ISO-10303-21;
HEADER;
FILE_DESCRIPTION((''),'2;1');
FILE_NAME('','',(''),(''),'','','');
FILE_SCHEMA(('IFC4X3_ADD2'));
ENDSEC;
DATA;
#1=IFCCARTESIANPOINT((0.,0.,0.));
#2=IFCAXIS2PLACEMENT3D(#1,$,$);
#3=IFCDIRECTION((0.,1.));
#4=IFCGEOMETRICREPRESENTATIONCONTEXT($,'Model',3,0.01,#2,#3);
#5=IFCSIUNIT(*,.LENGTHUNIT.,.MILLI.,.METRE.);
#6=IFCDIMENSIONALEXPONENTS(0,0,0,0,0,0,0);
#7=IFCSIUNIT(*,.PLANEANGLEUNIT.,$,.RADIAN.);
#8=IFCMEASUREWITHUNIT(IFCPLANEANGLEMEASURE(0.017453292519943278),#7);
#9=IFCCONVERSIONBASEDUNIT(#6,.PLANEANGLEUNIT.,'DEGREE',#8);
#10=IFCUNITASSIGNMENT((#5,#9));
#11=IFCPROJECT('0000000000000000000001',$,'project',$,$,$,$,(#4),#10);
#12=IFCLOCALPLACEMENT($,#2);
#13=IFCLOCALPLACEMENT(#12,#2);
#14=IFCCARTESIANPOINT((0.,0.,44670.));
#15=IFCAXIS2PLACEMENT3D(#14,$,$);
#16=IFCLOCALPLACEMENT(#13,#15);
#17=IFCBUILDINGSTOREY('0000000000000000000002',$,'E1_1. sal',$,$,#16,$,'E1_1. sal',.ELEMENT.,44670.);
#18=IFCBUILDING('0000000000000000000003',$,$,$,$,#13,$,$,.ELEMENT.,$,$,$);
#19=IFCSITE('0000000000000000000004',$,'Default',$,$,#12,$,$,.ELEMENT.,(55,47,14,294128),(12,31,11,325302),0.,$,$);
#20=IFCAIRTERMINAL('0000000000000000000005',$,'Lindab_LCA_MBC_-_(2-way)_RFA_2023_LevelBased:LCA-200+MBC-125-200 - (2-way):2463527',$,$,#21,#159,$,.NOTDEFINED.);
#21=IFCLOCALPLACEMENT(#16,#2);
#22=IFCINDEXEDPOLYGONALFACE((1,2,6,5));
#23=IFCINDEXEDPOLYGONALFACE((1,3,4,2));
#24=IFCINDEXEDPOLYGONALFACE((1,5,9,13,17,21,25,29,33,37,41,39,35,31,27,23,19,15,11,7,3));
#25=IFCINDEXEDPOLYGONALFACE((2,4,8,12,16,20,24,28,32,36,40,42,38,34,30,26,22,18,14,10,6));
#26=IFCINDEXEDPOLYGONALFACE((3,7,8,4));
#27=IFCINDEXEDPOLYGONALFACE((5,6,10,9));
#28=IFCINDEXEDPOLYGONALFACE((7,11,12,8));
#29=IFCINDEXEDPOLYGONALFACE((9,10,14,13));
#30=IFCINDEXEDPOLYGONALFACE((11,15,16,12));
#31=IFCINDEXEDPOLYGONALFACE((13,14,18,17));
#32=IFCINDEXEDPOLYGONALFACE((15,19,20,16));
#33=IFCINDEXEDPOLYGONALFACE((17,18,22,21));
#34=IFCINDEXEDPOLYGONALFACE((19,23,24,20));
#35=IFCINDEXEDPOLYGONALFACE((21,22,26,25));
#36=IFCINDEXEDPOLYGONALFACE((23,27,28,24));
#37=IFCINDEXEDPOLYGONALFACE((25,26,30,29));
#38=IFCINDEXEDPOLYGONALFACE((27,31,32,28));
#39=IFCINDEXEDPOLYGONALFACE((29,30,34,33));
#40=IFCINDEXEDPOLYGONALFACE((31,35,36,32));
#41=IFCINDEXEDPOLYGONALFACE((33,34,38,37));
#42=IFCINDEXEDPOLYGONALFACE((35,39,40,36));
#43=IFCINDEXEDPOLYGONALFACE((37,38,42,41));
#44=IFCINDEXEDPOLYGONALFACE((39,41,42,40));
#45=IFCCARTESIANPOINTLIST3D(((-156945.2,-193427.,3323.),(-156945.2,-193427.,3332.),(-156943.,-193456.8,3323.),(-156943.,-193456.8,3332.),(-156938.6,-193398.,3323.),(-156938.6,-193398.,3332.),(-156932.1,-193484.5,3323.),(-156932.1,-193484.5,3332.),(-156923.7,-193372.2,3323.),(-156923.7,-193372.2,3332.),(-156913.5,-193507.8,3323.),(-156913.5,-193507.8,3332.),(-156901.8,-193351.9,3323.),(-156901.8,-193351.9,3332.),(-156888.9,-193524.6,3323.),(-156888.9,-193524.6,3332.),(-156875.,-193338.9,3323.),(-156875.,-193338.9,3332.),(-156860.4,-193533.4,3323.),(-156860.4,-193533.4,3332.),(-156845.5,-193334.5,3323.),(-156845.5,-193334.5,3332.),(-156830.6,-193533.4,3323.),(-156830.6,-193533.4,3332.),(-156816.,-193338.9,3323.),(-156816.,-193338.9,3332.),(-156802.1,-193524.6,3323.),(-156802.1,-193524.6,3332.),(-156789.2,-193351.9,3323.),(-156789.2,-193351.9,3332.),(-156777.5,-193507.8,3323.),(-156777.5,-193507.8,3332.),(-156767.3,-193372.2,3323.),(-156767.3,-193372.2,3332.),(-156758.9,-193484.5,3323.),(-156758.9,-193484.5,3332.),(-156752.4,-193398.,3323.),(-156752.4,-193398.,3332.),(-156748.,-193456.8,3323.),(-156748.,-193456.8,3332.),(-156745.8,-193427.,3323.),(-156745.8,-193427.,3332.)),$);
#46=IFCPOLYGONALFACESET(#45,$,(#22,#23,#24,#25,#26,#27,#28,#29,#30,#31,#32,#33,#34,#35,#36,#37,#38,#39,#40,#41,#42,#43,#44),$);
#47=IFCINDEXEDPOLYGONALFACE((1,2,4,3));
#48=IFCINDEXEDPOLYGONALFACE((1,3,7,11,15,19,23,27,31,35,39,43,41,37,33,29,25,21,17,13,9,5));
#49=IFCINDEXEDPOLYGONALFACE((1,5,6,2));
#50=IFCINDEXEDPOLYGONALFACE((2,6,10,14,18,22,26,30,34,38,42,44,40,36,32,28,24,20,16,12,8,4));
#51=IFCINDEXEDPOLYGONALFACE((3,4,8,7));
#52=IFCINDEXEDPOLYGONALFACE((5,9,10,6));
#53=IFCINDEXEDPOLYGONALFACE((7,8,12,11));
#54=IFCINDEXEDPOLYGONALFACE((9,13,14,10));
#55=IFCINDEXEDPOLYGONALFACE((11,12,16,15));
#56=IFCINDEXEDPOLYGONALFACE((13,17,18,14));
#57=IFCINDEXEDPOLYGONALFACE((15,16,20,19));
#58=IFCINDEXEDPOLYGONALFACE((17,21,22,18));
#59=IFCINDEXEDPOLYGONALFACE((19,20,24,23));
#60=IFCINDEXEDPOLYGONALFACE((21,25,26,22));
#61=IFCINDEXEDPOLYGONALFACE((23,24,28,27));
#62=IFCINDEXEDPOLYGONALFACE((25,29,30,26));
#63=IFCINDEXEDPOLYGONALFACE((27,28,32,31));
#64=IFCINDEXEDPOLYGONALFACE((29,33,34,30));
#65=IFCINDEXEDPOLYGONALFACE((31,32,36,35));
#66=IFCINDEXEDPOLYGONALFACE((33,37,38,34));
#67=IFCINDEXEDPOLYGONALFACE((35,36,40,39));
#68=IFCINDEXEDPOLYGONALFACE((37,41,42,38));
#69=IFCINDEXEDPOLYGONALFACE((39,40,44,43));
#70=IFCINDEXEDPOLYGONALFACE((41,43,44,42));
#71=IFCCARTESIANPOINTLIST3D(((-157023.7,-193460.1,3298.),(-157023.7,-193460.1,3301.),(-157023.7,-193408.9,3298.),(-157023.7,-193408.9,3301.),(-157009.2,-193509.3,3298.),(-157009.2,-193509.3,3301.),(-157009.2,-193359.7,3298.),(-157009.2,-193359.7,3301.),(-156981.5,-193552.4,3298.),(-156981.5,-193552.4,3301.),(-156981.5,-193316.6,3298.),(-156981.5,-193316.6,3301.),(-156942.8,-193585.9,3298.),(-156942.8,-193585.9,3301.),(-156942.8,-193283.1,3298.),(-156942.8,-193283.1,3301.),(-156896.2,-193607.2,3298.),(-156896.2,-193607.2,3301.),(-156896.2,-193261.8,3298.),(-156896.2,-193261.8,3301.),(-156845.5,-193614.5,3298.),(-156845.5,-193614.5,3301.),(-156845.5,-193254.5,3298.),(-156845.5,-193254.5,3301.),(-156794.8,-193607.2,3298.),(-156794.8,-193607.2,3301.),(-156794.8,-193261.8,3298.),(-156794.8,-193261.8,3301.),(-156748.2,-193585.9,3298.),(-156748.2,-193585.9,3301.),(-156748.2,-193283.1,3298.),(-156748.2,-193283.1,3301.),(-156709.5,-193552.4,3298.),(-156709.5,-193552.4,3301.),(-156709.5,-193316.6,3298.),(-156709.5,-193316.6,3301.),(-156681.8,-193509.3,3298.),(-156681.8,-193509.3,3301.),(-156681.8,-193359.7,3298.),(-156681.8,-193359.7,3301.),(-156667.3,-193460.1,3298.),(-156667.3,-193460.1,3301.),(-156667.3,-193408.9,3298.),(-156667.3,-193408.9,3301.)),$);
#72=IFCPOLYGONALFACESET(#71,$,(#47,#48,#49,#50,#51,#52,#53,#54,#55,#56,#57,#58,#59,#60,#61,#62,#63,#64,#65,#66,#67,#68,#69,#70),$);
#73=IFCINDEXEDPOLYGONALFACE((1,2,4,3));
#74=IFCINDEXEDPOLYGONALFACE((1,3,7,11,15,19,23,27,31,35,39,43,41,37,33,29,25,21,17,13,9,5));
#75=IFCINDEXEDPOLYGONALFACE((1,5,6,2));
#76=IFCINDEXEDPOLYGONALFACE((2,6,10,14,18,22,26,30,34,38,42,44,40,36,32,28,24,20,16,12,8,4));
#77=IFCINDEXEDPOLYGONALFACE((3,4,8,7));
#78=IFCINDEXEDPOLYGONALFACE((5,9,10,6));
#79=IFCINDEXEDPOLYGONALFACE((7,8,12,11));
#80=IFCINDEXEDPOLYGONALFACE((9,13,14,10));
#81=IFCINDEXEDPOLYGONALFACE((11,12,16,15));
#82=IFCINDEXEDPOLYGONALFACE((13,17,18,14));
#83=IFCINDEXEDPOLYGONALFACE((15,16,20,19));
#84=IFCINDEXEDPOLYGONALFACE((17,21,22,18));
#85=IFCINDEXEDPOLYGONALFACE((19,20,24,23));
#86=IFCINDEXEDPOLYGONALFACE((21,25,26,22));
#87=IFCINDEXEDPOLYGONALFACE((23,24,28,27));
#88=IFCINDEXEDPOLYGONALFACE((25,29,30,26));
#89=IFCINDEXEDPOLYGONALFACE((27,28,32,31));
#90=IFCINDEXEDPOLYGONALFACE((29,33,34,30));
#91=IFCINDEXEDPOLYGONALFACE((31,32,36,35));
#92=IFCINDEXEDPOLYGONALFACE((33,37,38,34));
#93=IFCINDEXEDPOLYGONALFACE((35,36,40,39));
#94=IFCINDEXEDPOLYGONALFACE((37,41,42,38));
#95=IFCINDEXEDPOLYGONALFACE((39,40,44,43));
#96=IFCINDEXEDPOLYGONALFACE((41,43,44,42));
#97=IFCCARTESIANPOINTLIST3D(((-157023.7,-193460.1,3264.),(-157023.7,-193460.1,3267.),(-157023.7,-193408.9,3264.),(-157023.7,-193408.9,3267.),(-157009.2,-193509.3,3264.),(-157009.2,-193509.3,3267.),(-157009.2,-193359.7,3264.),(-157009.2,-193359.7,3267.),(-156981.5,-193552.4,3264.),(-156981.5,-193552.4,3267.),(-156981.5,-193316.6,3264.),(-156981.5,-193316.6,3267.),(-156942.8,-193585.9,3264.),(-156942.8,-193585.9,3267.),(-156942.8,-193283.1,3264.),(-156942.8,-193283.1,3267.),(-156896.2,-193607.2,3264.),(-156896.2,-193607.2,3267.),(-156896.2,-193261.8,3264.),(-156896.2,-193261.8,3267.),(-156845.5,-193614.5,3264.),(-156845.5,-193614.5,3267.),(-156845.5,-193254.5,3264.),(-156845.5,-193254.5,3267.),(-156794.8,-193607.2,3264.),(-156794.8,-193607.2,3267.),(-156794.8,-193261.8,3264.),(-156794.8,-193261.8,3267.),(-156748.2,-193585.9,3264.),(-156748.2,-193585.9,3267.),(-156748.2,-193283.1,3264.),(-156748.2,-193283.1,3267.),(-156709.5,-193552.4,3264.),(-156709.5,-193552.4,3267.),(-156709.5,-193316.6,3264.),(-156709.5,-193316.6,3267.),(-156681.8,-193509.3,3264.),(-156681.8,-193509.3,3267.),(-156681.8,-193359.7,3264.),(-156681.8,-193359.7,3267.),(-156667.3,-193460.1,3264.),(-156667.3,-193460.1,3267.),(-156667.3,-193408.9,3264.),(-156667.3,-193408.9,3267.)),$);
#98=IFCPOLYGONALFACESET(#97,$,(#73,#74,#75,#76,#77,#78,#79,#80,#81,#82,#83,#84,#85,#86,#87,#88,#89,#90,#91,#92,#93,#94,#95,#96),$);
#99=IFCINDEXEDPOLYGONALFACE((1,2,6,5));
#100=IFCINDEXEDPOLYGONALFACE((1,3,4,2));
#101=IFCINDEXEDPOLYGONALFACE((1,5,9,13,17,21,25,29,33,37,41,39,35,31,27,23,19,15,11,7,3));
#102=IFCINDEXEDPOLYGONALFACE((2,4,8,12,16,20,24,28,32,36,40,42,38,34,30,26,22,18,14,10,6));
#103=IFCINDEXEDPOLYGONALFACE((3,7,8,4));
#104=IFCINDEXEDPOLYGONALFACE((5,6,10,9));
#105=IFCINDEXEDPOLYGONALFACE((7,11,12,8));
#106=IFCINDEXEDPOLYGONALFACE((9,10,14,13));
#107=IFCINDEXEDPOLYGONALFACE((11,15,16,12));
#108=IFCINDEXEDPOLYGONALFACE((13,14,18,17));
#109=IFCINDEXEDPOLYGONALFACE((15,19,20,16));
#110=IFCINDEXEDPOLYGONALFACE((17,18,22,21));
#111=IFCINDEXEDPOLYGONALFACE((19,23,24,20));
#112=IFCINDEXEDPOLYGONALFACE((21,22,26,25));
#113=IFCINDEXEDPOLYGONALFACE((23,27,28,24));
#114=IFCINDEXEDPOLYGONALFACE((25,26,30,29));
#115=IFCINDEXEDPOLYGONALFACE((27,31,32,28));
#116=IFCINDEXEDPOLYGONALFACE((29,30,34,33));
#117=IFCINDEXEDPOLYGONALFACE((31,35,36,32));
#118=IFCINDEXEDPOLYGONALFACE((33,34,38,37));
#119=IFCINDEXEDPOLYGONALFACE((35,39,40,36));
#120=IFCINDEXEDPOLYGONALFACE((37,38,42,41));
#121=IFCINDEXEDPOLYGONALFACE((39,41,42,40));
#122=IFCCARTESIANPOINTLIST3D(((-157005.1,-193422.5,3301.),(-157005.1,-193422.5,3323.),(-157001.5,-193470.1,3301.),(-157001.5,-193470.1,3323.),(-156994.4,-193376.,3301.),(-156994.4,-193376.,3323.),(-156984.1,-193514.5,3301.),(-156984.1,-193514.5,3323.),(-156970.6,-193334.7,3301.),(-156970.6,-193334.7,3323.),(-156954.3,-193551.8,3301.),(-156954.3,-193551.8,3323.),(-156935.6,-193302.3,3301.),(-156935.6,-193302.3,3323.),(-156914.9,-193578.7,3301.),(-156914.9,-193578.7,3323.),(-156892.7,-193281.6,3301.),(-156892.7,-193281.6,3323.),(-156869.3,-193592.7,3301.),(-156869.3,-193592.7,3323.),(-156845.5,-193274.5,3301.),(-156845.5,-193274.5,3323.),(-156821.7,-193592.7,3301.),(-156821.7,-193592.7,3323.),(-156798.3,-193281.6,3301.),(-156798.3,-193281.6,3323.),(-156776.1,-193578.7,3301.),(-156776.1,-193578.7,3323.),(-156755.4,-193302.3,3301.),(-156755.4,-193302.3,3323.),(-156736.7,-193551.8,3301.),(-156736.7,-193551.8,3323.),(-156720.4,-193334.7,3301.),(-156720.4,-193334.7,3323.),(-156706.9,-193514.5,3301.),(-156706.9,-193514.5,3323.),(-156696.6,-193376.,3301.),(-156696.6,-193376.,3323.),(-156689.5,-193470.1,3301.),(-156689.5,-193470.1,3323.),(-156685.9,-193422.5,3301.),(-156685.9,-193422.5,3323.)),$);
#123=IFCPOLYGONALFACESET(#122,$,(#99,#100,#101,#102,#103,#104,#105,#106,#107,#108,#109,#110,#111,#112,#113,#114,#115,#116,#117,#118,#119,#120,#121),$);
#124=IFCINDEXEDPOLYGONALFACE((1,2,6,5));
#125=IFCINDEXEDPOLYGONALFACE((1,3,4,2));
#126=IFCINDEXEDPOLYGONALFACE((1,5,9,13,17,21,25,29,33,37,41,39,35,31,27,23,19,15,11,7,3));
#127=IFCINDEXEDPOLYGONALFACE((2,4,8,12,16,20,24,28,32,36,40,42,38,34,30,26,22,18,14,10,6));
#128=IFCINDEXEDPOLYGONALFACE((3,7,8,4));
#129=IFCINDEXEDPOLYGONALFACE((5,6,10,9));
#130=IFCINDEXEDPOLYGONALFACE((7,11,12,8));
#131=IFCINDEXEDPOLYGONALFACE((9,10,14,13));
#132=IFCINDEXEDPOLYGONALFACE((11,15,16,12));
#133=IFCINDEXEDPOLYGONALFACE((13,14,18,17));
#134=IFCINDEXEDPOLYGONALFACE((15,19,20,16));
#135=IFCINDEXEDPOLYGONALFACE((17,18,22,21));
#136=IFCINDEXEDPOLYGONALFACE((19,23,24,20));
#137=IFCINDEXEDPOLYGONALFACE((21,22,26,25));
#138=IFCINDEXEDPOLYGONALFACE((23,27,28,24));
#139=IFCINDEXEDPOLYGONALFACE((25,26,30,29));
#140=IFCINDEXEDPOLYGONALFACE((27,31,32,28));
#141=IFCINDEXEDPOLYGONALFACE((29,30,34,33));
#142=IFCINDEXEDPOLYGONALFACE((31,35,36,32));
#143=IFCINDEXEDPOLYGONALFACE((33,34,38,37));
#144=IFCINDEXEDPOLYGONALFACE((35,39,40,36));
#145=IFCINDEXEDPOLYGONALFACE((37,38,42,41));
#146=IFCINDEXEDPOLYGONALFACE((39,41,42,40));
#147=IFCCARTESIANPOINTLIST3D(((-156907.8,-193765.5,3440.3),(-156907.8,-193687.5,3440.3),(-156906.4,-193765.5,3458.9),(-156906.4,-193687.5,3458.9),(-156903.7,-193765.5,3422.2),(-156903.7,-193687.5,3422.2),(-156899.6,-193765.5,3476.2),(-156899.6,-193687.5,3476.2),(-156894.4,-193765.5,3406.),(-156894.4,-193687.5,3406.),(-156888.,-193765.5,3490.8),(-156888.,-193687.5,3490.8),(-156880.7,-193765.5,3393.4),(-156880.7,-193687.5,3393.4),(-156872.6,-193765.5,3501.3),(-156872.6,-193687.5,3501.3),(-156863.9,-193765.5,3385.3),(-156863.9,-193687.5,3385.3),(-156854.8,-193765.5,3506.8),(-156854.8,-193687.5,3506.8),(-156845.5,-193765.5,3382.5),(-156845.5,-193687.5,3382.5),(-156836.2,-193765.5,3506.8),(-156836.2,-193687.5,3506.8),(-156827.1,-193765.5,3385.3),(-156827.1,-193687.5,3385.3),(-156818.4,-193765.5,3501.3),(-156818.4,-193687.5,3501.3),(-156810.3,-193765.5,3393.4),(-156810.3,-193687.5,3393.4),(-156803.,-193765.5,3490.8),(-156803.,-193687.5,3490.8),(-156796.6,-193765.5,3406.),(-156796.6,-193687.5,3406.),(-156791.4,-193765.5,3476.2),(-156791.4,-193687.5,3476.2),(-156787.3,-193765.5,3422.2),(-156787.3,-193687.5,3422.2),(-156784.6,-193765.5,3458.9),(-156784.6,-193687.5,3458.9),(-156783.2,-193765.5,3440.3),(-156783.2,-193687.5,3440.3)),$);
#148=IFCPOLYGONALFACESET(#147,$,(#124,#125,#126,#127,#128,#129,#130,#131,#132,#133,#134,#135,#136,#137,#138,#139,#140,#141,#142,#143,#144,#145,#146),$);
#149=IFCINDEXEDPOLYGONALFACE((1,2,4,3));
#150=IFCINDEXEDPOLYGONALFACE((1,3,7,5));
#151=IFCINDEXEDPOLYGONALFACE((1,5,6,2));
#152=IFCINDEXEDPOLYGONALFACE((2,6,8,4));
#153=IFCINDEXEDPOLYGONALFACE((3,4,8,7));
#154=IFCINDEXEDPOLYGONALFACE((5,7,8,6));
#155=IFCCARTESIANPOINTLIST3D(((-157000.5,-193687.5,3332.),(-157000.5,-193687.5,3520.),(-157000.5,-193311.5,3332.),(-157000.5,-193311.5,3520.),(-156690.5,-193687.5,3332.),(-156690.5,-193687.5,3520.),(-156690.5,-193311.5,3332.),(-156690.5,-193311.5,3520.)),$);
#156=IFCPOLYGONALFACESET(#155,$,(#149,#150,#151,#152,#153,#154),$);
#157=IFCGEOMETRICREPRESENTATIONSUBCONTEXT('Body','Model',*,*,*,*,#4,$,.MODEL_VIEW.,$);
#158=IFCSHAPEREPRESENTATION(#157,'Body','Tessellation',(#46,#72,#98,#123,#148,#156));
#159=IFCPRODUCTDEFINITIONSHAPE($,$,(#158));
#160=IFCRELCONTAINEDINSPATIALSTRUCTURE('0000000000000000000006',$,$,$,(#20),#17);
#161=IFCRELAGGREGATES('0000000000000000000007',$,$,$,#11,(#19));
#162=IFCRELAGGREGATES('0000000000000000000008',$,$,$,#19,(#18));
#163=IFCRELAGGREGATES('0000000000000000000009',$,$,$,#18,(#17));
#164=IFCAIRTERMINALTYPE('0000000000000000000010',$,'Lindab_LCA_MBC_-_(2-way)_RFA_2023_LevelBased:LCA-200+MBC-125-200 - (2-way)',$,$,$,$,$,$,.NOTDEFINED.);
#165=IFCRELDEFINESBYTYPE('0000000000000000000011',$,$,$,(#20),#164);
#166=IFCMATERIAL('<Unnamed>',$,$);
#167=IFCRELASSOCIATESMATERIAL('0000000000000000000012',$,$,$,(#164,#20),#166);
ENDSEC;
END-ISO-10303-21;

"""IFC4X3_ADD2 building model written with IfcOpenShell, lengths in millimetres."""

from ifc_helpers import new_model, entity, si_unit, converted_unit, direction, frame, frame_2d, origin, origin_2d_with_axis, place, context, subcontext, project, spatial, rectangle, circle, extrude, source, transform, mapped, material, type_object, type_shapes, element, save


model = new_model("IFC4X3_ADD2")

# Units and contexts
model_context = context("Model", 3, precision=0.01, world=origin(), true_north=direction((0.0, 1.0)))
body_context = subcontext(model_context, "Body", "Model", "MODEL_VIEW")
ifc_project = project(units=[si_unit("LENGTHUNIT", "METRE", prefix="MILLI"), converted_unit("PLANEANGLEUNIT", "DEGREE", entity("IfcPlaneAngleMeasure", 0.017453292519943278), si_unit("PLANEANGLEUNIT", "RADIAN"), dimensions=[0, 0, 0, 0, 0, 0, 0])], contexts=[model_context])

# Site, building, storey
site_placement = place(None, origin())
site = spatial("IfcSite", under=ifc_project, at=site_placement, Name="Default", CompositionType="ELEMENT", RefLatitude=(55, 47, 14, 294128), RefLongitude=(12, 31, 11, 325302), RefElevation=0.0)
building_placement = place(site_placement, origin())
building = spatial("IfcBuilding", under=site, at=building_placement, CompositionType="ELEMENT")
storey_placement = place(building_placement, frame((0.0, 0.0, 44670.0)))
storey = spatial("IfcBuildingStorey", under=building, at=storey_placement, Name="E1_1. sal", LongName="E1_1. sal", CompositionType="ELEMENT", Elevation=44670.0)

# Air terminal
ifc_material_1 = material(Name="<Unnamed>")
air_terminal_type_1 = type_object("IfcAirTerminalType", Name="Lindab_LCA_MBC_-_(2-way)_RFA_2023_LevelBased:LCA-200+MBC-125-200 - (2-way)", PredefinedType="NOTDEFINED", material=ifc_material_1)
shared_shape_1 = source(origin(), body_context, "Body", "SweptSolid", [
    extrude(circle(Radius=100.0, at=frame_2d((0.0, 0.0), x_axis=(1.0, 0.0))), frame((0.0, 0.0, 22.0)), (0.0, 0.0, 1.0), 9.0),
    extrude(circle(Radius=180.0, at=frame_2d((0.0, 0.0), x_axis=(1.0, 0.0))), frame((0.0, 0.0, -3.0)), (0.0, 0.0, 1.0), 3.0),
    extrude(circle(Radius=180.0, at=frame_2d((0.0, 0.0), x_axis=(1.0, 0.0))), frame((0.0, 0.0, -37.0)), (0.0, 0.0, 1.0), 3.0),
    extrude(circle(Radius=160.0, at=frame_2d((0.0, 0.0), x_axis=(1.0, 0.0))), origin(), (0.0, 0.0, 1.0), 22.0),
    extrude(circle(Radius=62.5, at=frame_2d((0.0, 0.0), x_axis=(1.0, 0.0))), frame((-331.0, 0.0, 144.0), z_axis=(1.0, 0.0, 0.0), x_axis=(0.0, 0.0, -1.0)), (0.0, 0.0, 1.0), 78.0),
    extrude(rectangle(XDim=310.0, YDim=376.0, at=origin_2d_with_axis()), frame((-65.0, 0.0, 31.0), z_axis=(0.0, 0.0, 1.0), x_axis=(0.0, -1.0, 0.0)), (0.0, 0.0, 1.0), 188.0),
])
type_shapes(air_terminal_type_1, [shared_shape_1])
for number, where, z_axis, x_axis, name in (
    (1, (-156845.5, -193434.5, 3301.0), (0.0, 0.0, 1.0), (0.0, 1.0, 0.0), "Lindab_LCA_MBC_-_(2-way)_RFA_2023_LevelBased:LCA-200+MBC-125-200 - (2-way):2463527"),
):
    element("IfcAirTerminal", number, at=place(storey_placement, frame(where, z_axis=z_axis, x_axis=x_axis)), inside=storey, type_object=air_terminal_type_1, material=ifc_material_1, Name=name, PredefinedType="NOTDEFINED", context=body_context, shape_type="MappedRepresentation", body=[
        mapped(shared_shape_1, transform((0.0, 0.0, 0.0), scale=1.0)),
    ])

save(model, "model.ifc")
